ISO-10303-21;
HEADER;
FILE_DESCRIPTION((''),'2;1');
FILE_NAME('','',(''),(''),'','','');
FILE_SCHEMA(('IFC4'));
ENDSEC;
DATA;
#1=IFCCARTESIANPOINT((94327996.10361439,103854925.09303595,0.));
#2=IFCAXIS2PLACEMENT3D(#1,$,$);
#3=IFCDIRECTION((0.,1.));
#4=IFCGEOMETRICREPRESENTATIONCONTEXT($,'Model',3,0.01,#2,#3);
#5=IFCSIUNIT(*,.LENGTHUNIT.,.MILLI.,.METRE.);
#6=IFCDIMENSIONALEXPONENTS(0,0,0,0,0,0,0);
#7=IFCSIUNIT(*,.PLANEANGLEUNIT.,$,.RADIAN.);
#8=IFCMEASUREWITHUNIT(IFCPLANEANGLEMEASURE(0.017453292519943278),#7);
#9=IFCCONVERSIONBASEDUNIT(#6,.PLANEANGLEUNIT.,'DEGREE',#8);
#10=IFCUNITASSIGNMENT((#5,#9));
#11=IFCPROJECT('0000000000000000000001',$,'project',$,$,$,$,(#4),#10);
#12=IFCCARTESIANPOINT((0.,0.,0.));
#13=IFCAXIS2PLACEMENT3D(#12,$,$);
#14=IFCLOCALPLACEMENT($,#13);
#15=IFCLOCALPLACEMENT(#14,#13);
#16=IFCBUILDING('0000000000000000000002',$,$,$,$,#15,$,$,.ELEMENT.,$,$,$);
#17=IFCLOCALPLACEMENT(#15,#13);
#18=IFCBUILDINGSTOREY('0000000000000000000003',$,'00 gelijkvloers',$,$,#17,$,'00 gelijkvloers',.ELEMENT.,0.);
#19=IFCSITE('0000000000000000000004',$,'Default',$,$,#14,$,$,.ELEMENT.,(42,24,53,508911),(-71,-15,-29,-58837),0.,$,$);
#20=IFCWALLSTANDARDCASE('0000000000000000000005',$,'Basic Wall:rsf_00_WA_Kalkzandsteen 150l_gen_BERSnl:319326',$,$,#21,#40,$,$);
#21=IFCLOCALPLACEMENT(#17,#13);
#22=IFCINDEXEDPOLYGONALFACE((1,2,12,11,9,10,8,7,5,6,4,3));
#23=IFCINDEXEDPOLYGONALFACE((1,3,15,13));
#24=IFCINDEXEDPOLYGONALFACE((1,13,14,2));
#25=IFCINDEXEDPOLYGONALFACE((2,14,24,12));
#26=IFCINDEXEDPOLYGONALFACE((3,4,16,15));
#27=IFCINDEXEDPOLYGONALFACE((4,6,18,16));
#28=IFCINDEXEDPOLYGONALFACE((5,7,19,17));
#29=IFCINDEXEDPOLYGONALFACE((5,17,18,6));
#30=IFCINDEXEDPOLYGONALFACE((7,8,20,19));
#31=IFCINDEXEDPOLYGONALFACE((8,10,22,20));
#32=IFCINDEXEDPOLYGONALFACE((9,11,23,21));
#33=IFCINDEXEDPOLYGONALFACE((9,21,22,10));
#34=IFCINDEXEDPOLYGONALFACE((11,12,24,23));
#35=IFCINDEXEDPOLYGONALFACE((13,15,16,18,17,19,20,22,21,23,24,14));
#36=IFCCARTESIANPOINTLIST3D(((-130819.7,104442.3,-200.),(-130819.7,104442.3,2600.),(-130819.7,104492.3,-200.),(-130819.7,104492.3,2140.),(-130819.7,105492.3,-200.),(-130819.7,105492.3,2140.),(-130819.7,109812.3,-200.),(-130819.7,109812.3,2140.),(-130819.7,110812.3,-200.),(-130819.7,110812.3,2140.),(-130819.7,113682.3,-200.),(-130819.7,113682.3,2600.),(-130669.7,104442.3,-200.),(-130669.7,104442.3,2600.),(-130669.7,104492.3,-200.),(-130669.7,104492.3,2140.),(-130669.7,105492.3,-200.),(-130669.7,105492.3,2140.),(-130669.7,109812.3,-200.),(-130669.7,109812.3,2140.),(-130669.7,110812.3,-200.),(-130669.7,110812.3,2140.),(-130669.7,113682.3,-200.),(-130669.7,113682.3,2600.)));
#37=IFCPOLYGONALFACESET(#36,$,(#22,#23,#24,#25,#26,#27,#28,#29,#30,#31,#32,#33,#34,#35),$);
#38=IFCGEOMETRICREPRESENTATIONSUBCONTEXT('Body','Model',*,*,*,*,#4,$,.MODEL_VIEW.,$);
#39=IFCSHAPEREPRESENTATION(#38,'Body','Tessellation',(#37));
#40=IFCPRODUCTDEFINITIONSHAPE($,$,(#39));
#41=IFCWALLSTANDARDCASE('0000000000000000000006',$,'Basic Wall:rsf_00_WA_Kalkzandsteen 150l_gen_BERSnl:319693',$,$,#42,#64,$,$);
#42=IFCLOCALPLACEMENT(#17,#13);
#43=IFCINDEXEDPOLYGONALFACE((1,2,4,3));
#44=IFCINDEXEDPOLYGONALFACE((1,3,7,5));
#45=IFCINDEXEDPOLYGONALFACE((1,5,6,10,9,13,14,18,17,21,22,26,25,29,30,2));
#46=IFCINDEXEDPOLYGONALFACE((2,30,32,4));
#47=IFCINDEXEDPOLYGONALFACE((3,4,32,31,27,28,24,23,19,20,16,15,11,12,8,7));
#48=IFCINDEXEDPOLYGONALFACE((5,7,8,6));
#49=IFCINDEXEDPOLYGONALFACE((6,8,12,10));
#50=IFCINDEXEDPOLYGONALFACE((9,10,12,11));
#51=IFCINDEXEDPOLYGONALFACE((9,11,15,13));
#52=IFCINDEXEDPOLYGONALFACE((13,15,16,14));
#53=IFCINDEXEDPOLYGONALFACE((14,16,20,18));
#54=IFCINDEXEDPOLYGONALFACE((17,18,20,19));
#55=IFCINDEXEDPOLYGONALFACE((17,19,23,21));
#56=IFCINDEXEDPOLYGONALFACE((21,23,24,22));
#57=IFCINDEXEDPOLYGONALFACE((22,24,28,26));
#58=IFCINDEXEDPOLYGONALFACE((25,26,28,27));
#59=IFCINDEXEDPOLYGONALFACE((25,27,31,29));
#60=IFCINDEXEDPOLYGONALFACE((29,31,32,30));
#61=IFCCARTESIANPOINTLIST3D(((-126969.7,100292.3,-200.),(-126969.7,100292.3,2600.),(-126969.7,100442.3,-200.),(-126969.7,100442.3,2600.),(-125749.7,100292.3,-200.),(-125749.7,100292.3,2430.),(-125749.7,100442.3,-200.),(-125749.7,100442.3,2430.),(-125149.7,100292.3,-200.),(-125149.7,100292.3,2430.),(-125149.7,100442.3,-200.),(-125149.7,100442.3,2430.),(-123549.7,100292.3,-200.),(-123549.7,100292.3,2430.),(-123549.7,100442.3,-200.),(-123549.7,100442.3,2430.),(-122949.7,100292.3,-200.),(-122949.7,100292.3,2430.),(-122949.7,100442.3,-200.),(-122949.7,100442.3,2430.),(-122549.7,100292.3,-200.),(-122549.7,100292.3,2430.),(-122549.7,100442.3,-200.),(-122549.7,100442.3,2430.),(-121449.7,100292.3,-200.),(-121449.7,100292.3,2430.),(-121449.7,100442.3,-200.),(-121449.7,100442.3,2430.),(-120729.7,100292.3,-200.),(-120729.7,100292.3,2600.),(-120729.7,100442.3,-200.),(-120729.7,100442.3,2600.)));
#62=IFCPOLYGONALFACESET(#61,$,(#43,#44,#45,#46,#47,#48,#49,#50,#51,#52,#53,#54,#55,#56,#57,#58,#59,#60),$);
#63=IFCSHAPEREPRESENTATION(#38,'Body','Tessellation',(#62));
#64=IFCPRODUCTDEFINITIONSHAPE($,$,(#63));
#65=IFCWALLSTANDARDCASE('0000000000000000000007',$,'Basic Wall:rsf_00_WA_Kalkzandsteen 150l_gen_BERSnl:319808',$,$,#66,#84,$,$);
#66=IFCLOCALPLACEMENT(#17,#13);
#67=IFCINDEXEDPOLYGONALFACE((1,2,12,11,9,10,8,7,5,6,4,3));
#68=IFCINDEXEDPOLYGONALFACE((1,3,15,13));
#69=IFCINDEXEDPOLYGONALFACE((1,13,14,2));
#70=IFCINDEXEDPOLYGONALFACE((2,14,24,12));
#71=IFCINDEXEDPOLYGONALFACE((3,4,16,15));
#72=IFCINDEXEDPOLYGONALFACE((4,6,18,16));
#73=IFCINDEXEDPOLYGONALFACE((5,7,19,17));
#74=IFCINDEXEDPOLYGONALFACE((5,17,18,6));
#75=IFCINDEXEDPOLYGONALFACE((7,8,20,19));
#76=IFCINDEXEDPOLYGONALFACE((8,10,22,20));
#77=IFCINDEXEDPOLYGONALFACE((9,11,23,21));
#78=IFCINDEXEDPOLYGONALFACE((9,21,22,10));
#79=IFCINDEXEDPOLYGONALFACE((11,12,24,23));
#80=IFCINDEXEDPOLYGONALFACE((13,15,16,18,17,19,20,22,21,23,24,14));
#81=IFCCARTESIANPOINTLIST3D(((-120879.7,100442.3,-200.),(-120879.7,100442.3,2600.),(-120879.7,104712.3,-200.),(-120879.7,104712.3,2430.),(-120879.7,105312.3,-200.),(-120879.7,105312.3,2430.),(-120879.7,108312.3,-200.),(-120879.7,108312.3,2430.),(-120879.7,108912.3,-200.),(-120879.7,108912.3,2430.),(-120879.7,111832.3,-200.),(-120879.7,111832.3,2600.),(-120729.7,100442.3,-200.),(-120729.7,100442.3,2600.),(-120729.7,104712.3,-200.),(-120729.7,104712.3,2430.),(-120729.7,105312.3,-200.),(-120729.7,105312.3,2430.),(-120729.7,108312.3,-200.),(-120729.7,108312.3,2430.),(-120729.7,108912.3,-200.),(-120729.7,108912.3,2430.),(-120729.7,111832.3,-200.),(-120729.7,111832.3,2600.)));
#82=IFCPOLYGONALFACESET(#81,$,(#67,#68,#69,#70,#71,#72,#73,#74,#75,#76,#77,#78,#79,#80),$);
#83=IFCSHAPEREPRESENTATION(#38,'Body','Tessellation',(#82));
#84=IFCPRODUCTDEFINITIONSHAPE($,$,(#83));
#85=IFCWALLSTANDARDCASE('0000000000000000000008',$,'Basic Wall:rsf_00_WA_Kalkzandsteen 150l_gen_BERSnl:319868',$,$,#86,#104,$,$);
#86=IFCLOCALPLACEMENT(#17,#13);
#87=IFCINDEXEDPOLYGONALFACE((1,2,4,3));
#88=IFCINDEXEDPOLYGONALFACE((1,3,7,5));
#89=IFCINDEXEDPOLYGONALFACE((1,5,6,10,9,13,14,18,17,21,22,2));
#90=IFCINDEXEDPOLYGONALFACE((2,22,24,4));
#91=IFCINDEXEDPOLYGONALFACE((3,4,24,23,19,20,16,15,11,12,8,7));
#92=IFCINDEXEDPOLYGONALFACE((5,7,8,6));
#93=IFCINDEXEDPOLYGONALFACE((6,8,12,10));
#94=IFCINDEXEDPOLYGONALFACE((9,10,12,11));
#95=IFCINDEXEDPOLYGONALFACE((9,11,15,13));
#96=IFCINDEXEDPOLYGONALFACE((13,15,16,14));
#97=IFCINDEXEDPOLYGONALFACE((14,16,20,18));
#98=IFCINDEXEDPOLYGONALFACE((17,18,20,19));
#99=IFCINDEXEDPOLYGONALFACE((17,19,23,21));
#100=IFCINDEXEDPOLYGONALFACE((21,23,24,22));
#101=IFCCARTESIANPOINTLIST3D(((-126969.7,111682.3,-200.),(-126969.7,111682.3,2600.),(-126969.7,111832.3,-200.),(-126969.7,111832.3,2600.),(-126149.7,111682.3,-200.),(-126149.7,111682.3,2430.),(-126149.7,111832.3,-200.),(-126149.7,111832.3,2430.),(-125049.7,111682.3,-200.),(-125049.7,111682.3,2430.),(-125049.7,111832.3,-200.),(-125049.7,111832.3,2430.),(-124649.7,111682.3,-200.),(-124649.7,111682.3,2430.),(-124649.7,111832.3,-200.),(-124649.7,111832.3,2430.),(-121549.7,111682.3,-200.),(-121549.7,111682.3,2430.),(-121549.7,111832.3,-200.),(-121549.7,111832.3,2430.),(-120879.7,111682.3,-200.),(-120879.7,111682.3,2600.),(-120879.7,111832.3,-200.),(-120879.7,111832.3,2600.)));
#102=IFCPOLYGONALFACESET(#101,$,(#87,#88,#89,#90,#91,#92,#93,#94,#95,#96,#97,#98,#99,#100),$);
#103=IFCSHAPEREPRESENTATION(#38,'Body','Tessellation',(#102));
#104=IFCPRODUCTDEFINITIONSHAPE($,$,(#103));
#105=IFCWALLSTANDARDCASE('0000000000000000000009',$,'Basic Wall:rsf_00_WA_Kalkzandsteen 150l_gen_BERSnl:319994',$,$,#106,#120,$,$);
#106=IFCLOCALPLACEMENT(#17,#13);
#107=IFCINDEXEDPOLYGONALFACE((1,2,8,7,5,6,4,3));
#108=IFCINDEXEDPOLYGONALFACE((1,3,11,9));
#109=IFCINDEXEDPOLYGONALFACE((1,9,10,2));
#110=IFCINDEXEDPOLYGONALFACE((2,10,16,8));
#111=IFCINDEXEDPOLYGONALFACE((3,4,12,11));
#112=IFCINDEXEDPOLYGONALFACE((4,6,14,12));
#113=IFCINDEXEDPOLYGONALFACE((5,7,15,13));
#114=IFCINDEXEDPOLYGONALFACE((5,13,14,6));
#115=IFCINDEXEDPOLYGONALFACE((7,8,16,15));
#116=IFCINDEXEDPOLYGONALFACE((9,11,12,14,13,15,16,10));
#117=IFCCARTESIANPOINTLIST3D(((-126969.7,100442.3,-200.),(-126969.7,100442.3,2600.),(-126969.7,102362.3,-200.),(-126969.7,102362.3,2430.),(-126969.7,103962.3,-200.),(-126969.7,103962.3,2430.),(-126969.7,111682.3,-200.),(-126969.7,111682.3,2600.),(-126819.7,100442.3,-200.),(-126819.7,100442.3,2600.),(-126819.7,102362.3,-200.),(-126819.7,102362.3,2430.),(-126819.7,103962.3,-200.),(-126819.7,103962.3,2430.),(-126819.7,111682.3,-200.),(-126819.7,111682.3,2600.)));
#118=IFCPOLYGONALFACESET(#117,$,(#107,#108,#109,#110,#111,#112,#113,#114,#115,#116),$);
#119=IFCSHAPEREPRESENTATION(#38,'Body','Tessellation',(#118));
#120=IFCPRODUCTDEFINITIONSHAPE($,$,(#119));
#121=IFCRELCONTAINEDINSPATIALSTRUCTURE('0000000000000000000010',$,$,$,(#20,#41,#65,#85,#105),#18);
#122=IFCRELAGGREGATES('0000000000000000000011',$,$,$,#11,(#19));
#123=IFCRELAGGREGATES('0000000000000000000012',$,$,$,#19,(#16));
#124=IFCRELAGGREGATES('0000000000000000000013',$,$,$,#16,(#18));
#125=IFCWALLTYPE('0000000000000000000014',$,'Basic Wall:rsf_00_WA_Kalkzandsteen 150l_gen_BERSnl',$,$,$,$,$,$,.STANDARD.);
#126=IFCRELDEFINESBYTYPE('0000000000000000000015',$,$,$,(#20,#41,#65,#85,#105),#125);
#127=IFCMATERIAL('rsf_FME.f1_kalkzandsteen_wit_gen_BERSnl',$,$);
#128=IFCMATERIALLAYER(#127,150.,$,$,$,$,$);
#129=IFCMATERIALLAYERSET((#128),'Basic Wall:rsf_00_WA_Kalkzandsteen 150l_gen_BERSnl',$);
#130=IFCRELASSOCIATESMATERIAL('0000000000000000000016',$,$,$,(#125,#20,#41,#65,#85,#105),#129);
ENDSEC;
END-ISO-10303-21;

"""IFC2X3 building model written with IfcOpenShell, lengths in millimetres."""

from ifc_helpers import new_model, entity, si_unit, converted_unit, direction, frame, frame_2d, origin, origin_2d_with_axis, place, context, subcontext, project, spatial, polyline, rectangle, extrude, clip, bounded_halfspace, material, layer, layer_set, layer_usage, type_object, element, save


model = new_model("IFC2X3")

# Units and contexts
model_context = context("Model", 3, precision=0.01, world=frame((94327996.10361439, 103854925.09303595, 0.0)), true_north=direction((0.0, 1.0)))
body_context = subcontext(model_context, "Body", "Model", "MODEL_VIEW")
ifc_project = project(units=[si_unit("LENGTHUNIT", "METRE", prefix="MILLI"), converted_unit("PLANEANGLEUNIT", "DEGREE", entity("IfcPlaneAngleMeasure", 0.017453292519943278), si_unit("PLANEANGLEUNIT", "RADIAN"), dimensions=[0, 0, 0, 0, 0, 0, 0])], contexts=[model_context])

# Site, building, storey
site_placement = place(None, origin())
site = spatial("IfcSite", under=ifc_project, at=site_placement, Name="Default", CompositionType="ELEMENT", RefLatitude=(42, 24, 53, 508911), RefLongitude=(-71, -15, -29, -58837), RefElevation=0.0)
building_placement = place(site_placement, origin())
building = spatial("IfcBuilding", under=site, at=building_placement, CompositionType="ELEMENT")
storey_placement = place(building_placement, origin())
storey = spatial("IfcBuildingStorey", under=building, at=storey_placement, Name="00 gelijkvloers", LongName="00 gelijkvloers", CompositionType="ELEMENT", Elevation=0.0)

# Shared definitions
ifc_material_1 = material(Name="rsf_FME.f1_kalkzandsteen_wit_gen_BERSnl")
ifc_layer_1 = layer(ifc_material_1, 150.0)
ifc_layer_set_1 = layer_set([ifc_layer_1], Name="Basic Wall:rsf_00_WA_Kalkzandsteen 150l_gen_BERSnl")
wall_type_1 = type_object("IfcWallType", Name="Basic Wall:rsf_00_WA_Kalkzandsteen 150l_gen_BERSnl", PredefinedType="STANDARD", material=ifc_layer_set_1)

# Walls, openings
ifc_layer_usage_1 = layer_usage(ifc_layer_set_1, "AXIS2", "POSITIVE", -75.0)
wall_1_placement = place(storey_placement, frame((-130744.7, 113682.3, -200.0), z_axis=(0.0, 0.0, 1.0), x_axis=(0.0, -1.0, 0.0)))
wall_1 = element("IfcWallStandardCase", 1, at=wall_1_placement, inside=storey, type_object=wall_type_1, material=ifc_layer_usage_1, Name="Basic Wall:rsf_00_WA_Kalkzandsteen 150l_gen_BERSnl:319326", context=body_context, shape_type="Clipping", body=[
    clip(extrude(rectangle(XDim=9240.0, YDim=150.0, at=frame_2d((4620.0, 0.0), x_axis=(-1.0, 0.0))), origin(), (0.0, 0.0, 1.0), 2800.0), bounded_halfspace(frame((9240.0, 75.0, 2800.0), z_axis=(0.0, 0.0, -1.0), x_axis=(-1.0, 0.0, 0.0)), True, frame((9240.0, 75.0, 2800.0)), polyline([(0.0, 0.0), (-9240.0, 0.0), (-9240.0, -150.0), (-7890.0, -150.0), (-7740.0, -150.0), (0.0, -150.0), (0.0, 0.0)]))),
])
opening_1_placement = place(wall_1_placement, frame((113682.3, 130744.7, 200.0), z_axis=(0.0, 0.0, 1.0), x_axis=(0.0, 1.0, 0.0)))
element("IfcOpeningElement", 2, at=opening_1_placement, cuts=wall_1, ObjectType="Opening", context=body_context, shape_type="SweptSolid", body=[
    extrude(rectangle(XDim=2340.0, YDim=1000.0, at=frame_2d((0.0, 0.0), x_axis=(0.0, 1.0))), frame((-132343.7, 104992.3, 970.0), z_axis=(1.0, 0.0, 0.0), x_axis=(0.0, 1.0, 0.0)), (0.0, 0.0, 1.0), 3048.0),
])
opening_2_placement = place(wall_1_placement, frame((113682.3, 130744.7, 200.0), z_axis=(0.0, 0.0, 1.0), x_axis=(0.0, 1.0, 0.0)))
element("IfcOpeningElement", 3, at=opening_2_placement, cuts=wall_1, ObjectType="Opening", context=body_context, shape_type="SweptSolid", body=[
    extrude(rectangle(XDim=2340.0, YDim=1000.0, at=frame_2d((0.0, 0.0), x_axis=(1.0, 0.0))), frame((-132193.7, 110312.3, 970.0), z_axis=(1.0, 0.0, 0.0), x_axis=(0.0, 0.0, 1.0)), (0.0, 0.0, 1.0), 3048.0),
])
ifc_layer_usage_2 = layer_usage(ifc_layer_set_1, "AXIS2", "NEGATIVE", 75.0)
wall_2_placement = place(storey_placement, frame((-126969.7, 100367.3, -200.0)))
wall_2 = element("IfcWallStandardCase", 4, at=wall_2_placement, inside=storey, type_object=wall_type_1, material=ifc_layer_usage_2, Name="Basic Wall:rsf_00_WA_Kalkzandsteen 150l_gen_BERSnl:319693", context=body_context, shape_type="Clipping", body=[
    clip(extrude(rectangle(XDim=6240.0, YDim=150.0, at=frame_2d((3120.0, 0.0), x_axis=(1.0, 0.0))), origin(), (0.0, 0.0, 1.0), 2800.0), bounded_halfspace(frame((0.0, -75.0, 2800.0), z_axis=(0.0, 0.0, -1.0), x_axis=(0.0, 1.0, 0.0)), True, frame((0.0, -75.0, 2800.0)), polyline([(0.0, 0.0), (6240.0, 0.0), (6240.0, 150.0), (6090.0, 150.0), (150.0, 150.0), (0.0, 150.0), (0.0, 0.0)]))),
])
opening_3_placement = place(wall_2_placement, frame((126969.7, -100367.3, 200.0)))
element("IfcOpeningElement", 5, at=opening_3_placement, cuts=wall_2, ObjectType="Opening", context=body_context, shape_type="SweptSolid", body=[
    extrude(rectangle(XDim=2630.0, YDim=1100.0, at=frame_2d((0.0, 0.0), x_axis=(0.0, 1.0))), frame((-121999.7, 98768.3, 1115.0), z_axis=(0.0, 1.0, 0.0), x_axis=(-1.0, 0.0, 0.0)), (0.0, 0.0, 1.0), 3048.0),
])
opening_4_placement = place(wall_2_placement, frame((126969.7, -100367.3, 200.0)))
element("IfcOpeningElement", 6, at=opening_4_placement, cuts=wall_2, ObjectType="Opening", context=body_context, shape_type="SweptSolid", body=[
    extrude(rectangle(XDim=2630.0, YDim=600.0, at=origin_2d_with_axis()), frame((-123249.7, 98918.3, 1115.0), z_axis=(0.0, 1.0, 0.0), x_axis=(0.0, 0.0, 1.0)), (0.0, 0.0, 1.0), 3048.0),
])
opening_5_placement = place(wall_2_placement, frame((126969.7, -100367.3, 200.0)))
element("IfcOpeningElement", 7, at=opening_5_placement, cuts=wall_2, ObjectType="Opening", context=body_context, shape_type="SweptSolid", body=[
    extrude(rectangle(XDim=2630.0, YDim=600.0, at=origin_2d_with_axis()), frame((-125449.7, 98918.3, 1115.0), z_axis=(0.0, 1.0, 0.0), x_axis=(0.0, 0.0, 1.0)), (0.0, 0.0, 1.0), 3048.0),
])
ifc_layer_usage_3 = layer_usage(ifc_layer_set_1, "AXIS2", "NEGATIVE", 75.0)
wall_3_placement = place(storey_placement, frame((-120804.7, 100442.3, -200.0), z_axis=(0.0, 0.0, 1.0), x_axis=(0.0, 1.0, 0.0)))
wall_3 = element("IfcWallStandardCase", 8, at=wall_3_placement, inside=storey, type_object=wall_type_1, material=ifc_layer_usage_3, Name="Basic Wall:rsf_00_WA_Kalkzandsteen 150l_gen_BERSnl:319808", context=body_context, shape_type="Clipping", body=[
    clip(extrude(rectangle(XDim=11390.0, YDim=150.0, at=frame_2d((5695.0, 0.0), x_axis=(-1.0, 0.0))), origin(), (0.0, 0.0, 1.0), 2800.0), bounded_halfspace(frame((0.0, -75.0, 2800.0), z_axis=(0.0, 0.0, -1.0), x_axis=(1.0, 0.0, 0.0)), True, frame((0.0, -75.0, 2800.0)), polyline([(0.0, 0.0), (11390.0, 0.0), (11390.0, 150.0), (11240.0, 150.0), (0.0, 150.0), (0.0, 0.0)]))),
])
opening_6_placement = place(wall_3_placement, frame((-100442.3, -120804.7, 200.0), z_axis=(0.0, 0.0, 1.0), x_axis=(0.0, -1.0, 0.0)))
element("IfcOpeningElement", 9, at=opening_6_placement, cuts=wall_3, ObjectType="Opening", context=body_context, shape_type="SweptSolid", body=[
    extrude(rectangle(XDim=2630.0, YDim=600.0, at=frame_2d((0.0, 0.0), x_axis=(0.0, 1.0))), frame((-119205.7, 105012.3, 1115.0), z_axis=(-1.0, 0.0, 0.0), x_axis=(0.0, -1.0, 0.0)), (0.0, 0.0, 1.0), 3048.0),
])
opening_7_placement = place(wall_3_placement, frame((-100442.3, -120804.7, 200.0), z_axis=(0.0, 0.0, 1.0), x_axis=(0.0, -1.0, 0.0)))
element("IfcOpeningElement", 10, at=opening_7_placement, cuts=wall_3, ObjectType="Opening", context=body_context, shape_type="SweptSolid", body=[
    extrude(rectangle(XDim=2630.0, YDim=600.0, at=frame_2d((0.0, 0.0), x_axis=(0.0, 1.0))), frame((-119205.7, 108612.3, 1115.0), z_axis=(-1.0, 0.0, 0.0), x_axis=(0.0, -1.0, 0.0)), (0.0, 0.0, 1.0), 3048.0),
])
ifc_layer_usage_4 = layer_usage(ifc_layer_set_1, "AXIS2", "NEGATIVE", 75.0)
wall_4_placement = place(storey_placement, frame((-120879.7, 111757.3, -200.0), z_axis=(0.0, 0.0, 1.0), x_axis=(-1.0, 0.0, 0.0)))
wall_4 = element("IfcWallStandardCase", 11, at=wall_4_placement, inside=storey, type_object=wall_type_1, material=ifc_layer_usage_4, Name="Basic Wall:rsf_00_WA_Kalkzandsteen 150l_gen_BERSnl:319868", context=body_context, shape_type="Clipping", body=[
    clip(extrude(rectangle(XDim=6090.0, YDim=150.0, at=frame_2d((3045.0, 0.0), x_axis=(-1.0, 0.0))), origin(), (0.0, 0.0, 1.0), 2800.0), bounded_halfspace(frame((0.0, -75.0, 2800.0), z_axis=(0.0, 0.0, -1.0), x_axis=(0.0, -1.0, 0.0)), True, frame((0.0, -75.0, 2800.0)), polyline([(0.0, 0.0), (6090.0, 0.0), (6090.0, 150.0), (5940.0, 150.0), (0.0, 150.0), (0.0, 0.0)]))),
])
opening_8_placement = place(wall_4_placement, frame((-120879.7, 111757.3, 200.0), z_axis=(0.0, 0.0, 1.0), x_axis=(-1.0, 0.0, 0.0)))
element("IfcOpeningElement", 12, at=opening_8_placement, cuts=wall_4, ObjectType="Opening", context=body_context, shape_type="SweptSolid", body=[
    extrude(rectangle(XDim=2630.0, YDim=3100.0, at=frame_2d((0.0, 0.0), x_axis=(1.0, 0.0))), frame((-123099.7, 113206.3, 1115.0), z_axis=(0.0, -1.0, 0.0), x_axis=(0.0, 0.0, 1.0)), (0.0, 0.0, 1.0), 3048.0),
])
opening_9_placement = place(wall_4_placement, frame((-120879.7, 111757.3, 200.0), z_axis=(0.0, 0.0, 1.0), x_axis=(-1.0, 0.0, 0.0)))
element("IfcOpeningElement", 13, at=opening_9_placement, cuts=wall_4, ObjectType="Opening", context=body_context, shape_type="SweptSolid", body=[
    extrude(rectangle(XDim=2630.0, YDim=1100.0, at=frame_2d((0.0, 0.0), x_axis=(0.0, 1.0))), frame((-125599.7, 113356.3, 1115.0), z_axis=(0.0, -1.0, 0.0), x_axis=(1.0, 0.0, 0.0)), (0.0, 0.0, 1.0), 3048.0),
])

# Wall, opening
ifc_layer_usage_5 = layer_usage(ifc_layer_set_1, "AXIS2", "NEGATIVE", 75.0)
wall_5_placement = place(storey_placement, frame((-126894.7, 111682.3, -200.0), z_axis=(0.0, 0.0, 1.0), x_axis=(0.0, -1.0, 0.0)))
wall_5 = element("IfcWallStandardCase", 14, at=wall_5_placement, inside=storey, type_object=wall_type_1, material=ifc_layer_usage_5, Name="Basic Wall:rsf_00_WA_Kalkzandsteen 150l_gen_BERSnl:319994", context=body_context, shape_type="Clipping", body=[
    clip(extrude(rectangle(XDim=11240.0, YDim=150.0, at=frame_2d((5620.0, 0.0), x_axis=(-1.0, 0.0))), origin(), (0.0, 0.0, 1.0), 2800.0), bounded_halfspace(frame((11240.0, 75.0, 2800.0), z_axis=(0.0, 0.0, -1.0), x_axis=(-1.0, 0.0, 0.0)), True, frame((11240.0, 75.0, 2800.0)), polyline([(0.0, 0.0), (-11240.0, 0.0), (-11240.0, -150.0), (-3850.0, -150.0), (0.0, -150.0), (0.0, 0.0)]))),
])
opening_10_placement = place(wall_5_placement, frame((111682.3, 126894.7, 200.0), z_axis=(0.0, 0.0, 1.0), x_axis=(0.0, 1.0, 0.0)))
element("IfcOpeningElement", 15, at=opening_10_placement, cuts=wall_5, ObjectType="Opening", context=body_context, shape_type="SweptSolid", body=[
    extrude(rectangle(XDim=2630.0, YDim=1600.0, at=frame_2d((0.0, 0.0), x_axis=(1.0, 0.0))), frame((-128343.7, 103162.3, 1115.0), z_axis=(1.0, 0.0, 0.0), x_axis=(0.0, 0.0, 1.0)), (0.0, 0.0, 1.0), 3048.0),
])

save(model, "model.ifc")
